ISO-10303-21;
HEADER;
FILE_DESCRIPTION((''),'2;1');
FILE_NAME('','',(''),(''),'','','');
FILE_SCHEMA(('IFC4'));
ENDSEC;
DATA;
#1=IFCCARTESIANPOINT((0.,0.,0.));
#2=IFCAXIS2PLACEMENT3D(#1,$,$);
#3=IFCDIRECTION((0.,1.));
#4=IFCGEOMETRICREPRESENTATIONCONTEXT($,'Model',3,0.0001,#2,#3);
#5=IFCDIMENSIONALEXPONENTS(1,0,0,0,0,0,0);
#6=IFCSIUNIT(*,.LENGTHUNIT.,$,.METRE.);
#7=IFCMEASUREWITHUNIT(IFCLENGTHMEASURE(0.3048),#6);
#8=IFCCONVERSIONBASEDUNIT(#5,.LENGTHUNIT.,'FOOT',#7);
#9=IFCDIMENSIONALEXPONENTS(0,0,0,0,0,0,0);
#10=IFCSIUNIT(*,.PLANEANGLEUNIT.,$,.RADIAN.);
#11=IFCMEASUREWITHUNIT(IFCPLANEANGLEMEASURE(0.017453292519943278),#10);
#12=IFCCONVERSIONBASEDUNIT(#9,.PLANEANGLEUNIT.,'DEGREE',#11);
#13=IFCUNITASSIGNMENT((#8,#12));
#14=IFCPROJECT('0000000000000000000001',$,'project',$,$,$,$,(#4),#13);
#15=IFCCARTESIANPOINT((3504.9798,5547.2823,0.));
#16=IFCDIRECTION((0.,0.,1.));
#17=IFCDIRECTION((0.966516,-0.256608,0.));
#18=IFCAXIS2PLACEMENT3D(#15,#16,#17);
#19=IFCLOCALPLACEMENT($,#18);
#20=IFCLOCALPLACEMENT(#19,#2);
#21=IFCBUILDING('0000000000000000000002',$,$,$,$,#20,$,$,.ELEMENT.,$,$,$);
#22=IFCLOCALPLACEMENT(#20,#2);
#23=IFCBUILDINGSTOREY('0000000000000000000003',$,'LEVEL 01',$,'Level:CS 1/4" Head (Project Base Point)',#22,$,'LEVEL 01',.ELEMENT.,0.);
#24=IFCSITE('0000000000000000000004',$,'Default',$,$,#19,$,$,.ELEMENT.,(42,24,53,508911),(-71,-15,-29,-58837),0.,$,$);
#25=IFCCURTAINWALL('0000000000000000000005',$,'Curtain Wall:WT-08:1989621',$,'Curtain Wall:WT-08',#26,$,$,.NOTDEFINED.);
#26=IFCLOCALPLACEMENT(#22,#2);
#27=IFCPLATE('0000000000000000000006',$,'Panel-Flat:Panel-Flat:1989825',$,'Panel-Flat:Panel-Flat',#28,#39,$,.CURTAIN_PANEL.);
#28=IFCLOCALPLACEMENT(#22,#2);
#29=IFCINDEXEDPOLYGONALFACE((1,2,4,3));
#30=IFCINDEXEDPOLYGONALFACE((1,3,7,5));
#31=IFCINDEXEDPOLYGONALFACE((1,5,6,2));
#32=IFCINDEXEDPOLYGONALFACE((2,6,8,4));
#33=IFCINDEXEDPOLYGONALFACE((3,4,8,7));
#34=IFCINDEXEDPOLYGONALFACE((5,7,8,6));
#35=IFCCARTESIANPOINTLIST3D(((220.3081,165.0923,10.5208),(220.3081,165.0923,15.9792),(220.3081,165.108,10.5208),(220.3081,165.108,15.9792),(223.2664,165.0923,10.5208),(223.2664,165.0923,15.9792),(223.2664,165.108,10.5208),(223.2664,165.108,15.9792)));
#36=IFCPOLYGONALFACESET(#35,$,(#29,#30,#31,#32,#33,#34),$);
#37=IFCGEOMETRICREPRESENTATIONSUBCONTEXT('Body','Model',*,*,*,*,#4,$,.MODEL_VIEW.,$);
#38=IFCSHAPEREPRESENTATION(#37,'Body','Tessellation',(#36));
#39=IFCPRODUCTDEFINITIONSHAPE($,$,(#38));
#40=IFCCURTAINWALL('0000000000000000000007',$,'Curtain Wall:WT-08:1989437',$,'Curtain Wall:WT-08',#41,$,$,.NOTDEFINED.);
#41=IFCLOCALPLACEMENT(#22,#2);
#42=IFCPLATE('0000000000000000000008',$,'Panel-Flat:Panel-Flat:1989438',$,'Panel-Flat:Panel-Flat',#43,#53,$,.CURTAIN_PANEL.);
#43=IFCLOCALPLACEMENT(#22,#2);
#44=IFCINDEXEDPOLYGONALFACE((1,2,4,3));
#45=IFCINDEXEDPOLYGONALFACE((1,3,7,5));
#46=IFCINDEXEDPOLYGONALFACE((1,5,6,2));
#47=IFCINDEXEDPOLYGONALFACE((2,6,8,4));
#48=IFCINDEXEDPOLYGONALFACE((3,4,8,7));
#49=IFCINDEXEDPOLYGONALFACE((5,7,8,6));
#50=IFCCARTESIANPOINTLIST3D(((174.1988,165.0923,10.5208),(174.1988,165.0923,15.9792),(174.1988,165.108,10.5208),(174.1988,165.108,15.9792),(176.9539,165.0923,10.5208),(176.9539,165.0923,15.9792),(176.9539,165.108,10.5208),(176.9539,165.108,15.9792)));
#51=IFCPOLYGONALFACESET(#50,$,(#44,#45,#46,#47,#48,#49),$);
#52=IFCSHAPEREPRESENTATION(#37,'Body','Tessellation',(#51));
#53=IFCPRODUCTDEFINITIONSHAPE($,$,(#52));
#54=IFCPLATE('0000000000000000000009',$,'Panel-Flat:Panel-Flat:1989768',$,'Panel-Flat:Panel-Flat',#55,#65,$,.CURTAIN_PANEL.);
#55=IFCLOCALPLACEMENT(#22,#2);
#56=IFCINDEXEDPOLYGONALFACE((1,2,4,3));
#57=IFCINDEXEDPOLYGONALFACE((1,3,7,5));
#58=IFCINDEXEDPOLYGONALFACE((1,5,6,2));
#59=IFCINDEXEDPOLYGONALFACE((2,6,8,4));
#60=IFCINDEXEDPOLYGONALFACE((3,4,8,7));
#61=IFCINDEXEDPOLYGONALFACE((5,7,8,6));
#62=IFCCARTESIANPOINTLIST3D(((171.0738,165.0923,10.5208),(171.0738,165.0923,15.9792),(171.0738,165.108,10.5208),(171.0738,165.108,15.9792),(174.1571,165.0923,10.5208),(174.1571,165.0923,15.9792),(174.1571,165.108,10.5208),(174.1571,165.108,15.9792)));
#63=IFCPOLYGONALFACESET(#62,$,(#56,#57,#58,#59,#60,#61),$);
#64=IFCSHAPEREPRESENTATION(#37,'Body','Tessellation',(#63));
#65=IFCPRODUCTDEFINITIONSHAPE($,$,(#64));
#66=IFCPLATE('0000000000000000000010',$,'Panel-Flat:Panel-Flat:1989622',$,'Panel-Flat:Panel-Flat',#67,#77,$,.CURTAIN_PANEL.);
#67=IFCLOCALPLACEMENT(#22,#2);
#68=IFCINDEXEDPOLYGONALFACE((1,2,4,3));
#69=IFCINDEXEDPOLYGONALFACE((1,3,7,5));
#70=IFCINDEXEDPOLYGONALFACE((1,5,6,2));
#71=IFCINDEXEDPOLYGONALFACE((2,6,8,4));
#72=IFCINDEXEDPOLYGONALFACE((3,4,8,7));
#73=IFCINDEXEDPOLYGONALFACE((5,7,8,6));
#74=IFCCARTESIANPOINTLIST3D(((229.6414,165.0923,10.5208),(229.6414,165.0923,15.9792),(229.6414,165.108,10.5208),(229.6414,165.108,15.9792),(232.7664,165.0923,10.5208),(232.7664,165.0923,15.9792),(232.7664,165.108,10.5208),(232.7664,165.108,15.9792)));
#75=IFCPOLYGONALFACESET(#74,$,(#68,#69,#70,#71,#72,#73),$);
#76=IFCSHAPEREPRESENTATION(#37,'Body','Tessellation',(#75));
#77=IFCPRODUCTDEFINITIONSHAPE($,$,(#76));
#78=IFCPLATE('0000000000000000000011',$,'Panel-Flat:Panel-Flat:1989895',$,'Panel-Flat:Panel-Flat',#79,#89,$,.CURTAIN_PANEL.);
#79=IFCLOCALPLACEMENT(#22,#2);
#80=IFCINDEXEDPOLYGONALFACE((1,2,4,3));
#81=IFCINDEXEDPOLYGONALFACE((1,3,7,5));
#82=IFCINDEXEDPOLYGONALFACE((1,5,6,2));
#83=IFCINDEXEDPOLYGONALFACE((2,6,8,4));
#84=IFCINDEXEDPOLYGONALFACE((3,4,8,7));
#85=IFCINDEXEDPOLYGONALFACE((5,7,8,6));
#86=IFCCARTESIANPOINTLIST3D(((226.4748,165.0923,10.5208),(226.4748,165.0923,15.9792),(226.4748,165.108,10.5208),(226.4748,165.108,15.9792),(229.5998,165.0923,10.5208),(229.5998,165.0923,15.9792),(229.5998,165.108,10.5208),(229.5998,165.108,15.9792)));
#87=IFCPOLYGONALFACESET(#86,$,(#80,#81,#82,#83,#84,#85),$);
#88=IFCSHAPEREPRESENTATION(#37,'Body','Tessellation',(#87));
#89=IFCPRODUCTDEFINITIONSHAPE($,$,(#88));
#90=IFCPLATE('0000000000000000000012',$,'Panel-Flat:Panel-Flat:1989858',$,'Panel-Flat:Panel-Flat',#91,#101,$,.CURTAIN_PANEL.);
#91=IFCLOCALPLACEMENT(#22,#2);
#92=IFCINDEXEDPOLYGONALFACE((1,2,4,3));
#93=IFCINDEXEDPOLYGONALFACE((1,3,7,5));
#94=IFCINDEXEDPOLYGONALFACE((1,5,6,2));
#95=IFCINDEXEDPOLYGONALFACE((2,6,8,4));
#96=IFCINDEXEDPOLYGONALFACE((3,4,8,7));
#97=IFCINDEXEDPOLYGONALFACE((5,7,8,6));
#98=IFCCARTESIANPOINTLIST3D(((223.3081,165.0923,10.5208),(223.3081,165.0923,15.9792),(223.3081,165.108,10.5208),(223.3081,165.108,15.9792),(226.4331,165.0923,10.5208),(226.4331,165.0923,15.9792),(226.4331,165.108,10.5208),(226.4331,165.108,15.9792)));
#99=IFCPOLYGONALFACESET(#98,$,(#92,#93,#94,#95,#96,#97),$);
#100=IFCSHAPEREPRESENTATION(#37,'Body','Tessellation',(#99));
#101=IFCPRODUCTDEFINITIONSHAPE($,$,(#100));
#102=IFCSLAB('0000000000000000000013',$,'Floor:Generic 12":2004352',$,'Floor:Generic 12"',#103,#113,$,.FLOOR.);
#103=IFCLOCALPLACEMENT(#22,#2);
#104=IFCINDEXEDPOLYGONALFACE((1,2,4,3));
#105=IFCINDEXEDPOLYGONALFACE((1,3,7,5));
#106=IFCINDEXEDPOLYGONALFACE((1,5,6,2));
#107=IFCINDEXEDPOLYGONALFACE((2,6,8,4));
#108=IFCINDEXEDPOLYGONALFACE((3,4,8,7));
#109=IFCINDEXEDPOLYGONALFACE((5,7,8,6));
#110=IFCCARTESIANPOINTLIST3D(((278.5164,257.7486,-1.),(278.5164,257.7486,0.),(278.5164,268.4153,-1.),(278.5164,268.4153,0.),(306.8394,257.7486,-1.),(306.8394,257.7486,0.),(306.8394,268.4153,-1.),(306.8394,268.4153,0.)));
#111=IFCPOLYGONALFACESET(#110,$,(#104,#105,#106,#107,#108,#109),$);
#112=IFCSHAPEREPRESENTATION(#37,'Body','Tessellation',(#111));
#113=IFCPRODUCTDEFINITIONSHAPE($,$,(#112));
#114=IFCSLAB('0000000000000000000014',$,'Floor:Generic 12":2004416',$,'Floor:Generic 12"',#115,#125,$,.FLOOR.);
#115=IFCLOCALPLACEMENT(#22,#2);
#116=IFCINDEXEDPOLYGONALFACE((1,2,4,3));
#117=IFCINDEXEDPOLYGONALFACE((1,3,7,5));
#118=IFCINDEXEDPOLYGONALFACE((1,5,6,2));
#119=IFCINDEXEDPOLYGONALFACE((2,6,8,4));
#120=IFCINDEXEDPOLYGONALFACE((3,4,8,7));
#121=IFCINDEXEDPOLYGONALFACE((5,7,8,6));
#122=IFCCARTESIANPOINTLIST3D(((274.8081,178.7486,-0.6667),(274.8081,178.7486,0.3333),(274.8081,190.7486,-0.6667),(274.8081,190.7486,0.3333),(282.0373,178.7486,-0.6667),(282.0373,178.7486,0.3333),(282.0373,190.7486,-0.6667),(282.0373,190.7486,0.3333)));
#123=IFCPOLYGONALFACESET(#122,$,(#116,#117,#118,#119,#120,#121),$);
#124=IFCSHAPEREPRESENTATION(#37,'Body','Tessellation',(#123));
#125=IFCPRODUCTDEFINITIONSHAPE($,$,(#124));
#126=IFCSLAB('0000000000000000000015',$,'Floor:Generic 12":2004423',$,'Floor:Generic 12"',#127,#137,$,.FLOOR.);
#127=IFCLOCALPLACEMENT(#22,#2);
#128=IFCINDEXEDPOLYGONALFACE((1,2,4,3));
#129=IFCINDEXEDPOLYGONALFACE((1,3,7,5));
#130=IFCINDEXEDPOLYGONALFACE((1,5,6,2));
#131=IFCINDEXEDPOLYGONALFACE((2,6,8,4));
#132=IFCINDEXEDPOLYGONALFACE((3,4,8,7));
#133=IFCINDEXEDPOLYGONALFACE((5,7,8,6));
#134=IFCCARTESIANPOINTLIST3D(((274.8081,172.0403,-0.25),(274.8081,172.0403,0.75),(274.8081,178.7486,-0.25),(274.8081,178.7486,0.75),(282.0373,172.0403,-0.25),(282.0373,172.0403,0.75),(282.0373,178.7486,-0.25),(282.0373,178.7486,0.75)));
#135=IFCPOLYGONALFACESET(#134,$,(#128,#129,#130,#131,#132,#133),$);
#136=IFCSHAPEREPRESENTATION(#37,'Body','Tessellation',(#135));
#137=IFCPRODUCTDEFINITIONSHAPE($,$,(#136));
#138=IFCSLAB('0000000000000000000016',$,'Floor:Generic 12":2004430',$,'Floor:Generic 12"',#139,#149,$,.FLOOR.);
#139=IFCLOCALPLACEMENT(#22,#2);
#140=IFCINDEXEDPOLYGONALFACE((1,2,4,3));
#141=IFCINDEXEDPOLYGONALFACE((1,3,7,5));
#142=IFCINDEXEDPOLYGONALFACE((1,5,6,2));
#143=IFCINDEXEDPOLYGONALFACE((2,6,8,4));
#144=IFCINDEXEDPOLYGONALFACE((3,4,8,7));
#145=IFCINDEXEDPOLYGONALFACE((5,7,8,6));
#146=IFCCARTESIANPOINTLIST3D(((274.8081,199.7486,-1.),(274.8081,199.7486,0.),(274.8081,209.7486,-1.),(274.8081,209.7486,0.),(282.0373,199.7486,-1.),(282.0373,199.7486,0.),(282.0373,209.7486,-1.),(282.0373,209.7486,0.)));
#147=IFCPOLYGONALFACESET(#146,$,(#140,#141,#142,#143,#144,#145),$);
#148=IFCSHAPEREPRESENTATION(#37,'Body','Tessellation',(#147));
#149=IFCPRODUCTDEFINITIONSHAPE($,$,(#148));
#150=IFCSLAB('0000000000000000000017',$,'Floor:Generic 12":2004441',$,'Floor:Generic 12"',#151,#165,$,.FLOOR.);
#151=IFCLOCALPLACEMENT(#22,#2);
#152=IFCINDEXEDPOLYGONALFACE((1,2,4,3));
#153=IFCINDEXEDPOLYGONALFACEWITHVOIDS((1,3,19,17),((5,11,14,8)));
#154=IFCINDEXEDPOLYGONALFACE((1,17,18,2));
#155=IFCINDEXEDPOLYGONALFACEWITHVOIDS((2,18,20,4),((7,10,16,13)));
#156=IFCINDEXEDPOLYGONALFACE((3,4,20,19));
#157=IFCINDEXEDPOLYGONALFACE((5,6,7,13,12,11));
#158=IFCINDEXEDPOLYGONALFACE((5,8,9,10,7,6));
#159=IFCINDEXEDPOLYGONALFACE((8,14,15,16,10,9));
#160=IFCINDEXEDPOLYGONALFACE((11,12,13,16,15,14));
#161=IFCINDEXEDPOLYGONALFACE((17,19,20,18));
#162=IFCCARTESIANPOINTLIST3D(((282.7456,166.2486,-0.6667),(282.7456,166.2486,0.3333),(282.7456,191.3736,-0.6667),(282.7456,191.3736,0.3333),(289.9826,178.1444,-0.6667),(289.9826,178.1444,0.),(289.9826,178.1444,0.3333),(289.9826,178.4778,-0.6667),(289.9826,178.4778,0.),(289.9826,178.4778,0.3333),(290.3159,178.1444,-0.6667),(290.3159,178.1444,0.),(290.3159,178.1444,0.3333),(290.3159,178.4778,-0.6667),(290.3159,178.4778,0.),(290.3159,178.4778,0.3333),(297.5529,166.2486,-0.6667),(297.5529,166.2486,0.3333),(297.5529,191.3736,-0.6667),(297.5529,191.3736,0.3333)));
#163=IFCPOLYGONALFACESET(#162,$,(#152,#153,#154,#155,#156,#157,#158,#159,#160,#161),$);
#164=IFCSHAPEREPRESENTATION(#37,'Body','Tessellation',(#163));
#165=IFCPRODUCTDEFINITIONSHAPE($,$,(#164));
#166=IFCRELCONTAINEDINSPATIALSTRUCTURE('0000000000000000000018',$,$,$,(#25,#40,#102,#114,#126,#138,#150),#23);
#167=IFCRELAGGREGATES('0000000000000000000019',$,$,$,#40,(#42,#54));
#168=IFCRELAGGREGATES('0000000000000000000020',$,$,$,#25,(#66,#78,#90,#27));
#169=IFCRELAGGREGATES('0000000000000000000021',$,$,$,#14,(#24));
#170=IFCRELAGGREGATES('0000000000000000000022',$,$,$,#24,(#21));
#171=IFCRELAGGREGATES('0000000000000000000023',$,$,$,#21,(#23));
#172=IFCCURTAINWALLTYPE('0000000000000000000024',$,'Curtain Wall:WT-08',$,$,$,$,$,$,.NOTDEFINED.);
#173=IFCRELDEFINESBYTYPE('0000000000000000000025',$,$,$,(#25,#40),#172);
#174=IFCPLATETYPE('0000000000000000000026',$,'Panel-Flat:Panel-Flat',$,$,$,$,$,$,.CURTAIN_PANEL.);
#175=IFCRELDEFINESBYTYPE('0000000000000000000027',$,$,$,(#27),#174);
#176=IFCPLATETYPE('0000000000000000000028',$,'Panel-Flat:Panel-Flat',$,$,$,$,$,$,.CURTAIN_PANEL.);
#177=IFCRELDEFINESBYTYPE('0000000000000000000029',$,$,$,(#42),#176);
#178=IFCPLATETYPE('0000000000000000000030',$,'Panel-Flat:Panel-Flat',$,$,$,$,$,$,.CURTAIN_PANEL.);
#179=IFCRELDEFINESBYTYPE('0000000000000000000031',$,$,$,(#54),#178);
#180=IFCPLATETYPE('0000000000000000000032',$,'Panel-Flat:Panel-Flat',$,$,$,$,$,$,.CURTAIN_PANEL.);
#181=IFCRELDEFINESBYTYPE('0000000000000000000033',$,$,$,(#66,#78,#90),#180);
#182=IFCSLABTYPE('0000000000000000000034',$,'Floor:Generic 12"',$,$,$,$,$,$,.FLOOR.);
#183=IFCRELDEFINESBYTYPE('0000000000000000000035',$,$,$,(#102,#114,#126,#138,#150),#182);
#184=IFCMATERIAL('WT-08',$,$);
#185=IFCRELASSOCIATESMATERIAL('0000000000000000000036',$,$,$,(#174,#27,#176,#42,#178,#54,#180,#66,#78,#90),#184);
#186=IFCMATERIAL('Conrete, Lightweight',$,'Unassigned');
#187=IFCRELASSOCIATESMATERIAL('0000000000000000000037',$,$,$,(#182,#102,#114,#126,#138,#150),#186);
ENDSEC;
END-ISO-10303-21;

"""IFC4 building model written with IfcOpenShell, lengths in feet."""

from ifc_helpers import new_model, entity, si_unit, converted_unit, direction, frame, origin, place, context, subcontext, project, spatial, indexed_curve, outline, extrude, source, transform, mapped, material, type_object, type_shapes, element, aggregate, save


model = new_model("IFC4")

# Units and contexts
model_context = context("Model", 3, precision=0.0001, world=origin(), true_north=direction((0.0, 1.0)))
body_context = subcontext(model_context, "Body", "Model", "MODEL_VIEW")
ifc_project = project(units=[converted_unit("LENGTHUNIT", "FOOT", entity("IfcLengthMeasure", 0.3048), si_unit("LENGTHUNIT", "METRE"), dimensions=[1, 0, 0, 0, 0, 0, 0]), converted_unit("PLANEANGLEUNIT", "DEGREE", entity("IfcPlaneAngleMeasure", 0.017453292519943278), si_unit("PLANEANGLEUNIT", "RADIAN"), dimensions=[0, 0, 0, 0, 0, 0, 0])], contexts=[model_context])

# Site, building, storey
site_placement = place(None, frame((3504.9798, 5547.2823, 0.0), z_axis=(0.0, 0.0, 1.0), x_axis=(0.966516, -0.256608, 0.0)))
site = spatial("IfcSite", under=ifc_project, at=site_placement, Name="Default", CompositionType="ELEMENT", RefLatitude=(42, 24, 53, 508911), RefLongitude=(-71, -15, -29, -58837), RefElevation=0.0)
building_placement = place(site_placement, origin())
building = spatial("IfcBuilding", under=site, at=building_placement, CompositionType="ELEMENT")
storey_placement = place(building_placement, origin())
storey = spatial("IfcBuildingStorey", under=building, at=storey_placement, Name="LEVEL 01", ObjectType="Level:CS 1/4\" Head (Project Base Point)", LongName="LEVEL 01", CompositionType="ELEMENT", Elevation=0.0)

# Curtain wall, plate
curtain_wall_type_1 = type_object("IfcCurtainWallType", Name="Curtain Wall:WT-08", PredefinedType="NOTDEFINED")
curtain_wall_1_placement = place(storey_placement, origin())
curtain_wall_1 = element("IfcCurtainWall", 1, at=curtain_wall_1_placement, inside=storey, type_object=curtain_wall_type_1, Name="Curtain Wall:WT-08:1989621", ObjectType="Curtain Wall:WT-08", PredefinedType="NOTDEFINED")
ifc_material_1 = material(Name="WT-08")
plate_type_1 = type_object("IfcPlateType", Name="Panel-Flat:Panel-Flat", PredefinedType="CURTAIN_PANEL", material=ifc_material_1)
shared_shape_1 = source(origin(), body_context, "Body", "SweptSolid", [
    extrude(outline(indexed_curve([(-0.0078, -1.4792), (0.0078, -1.4792), (0.0078, 1.4792), (-0.0078, 1.4792), (-0.0078, -1.4792)], self_intersect=False)), frame((0.0, -0.0078, 0.0208), z_axis=(0.0, 0.0, 1.0), x_axis=(0.0, -1.0, 0.0)), (0.0, 0.0, 1.0), 5.4583),
])
type_shapes(plate_type_1, [shared_shape_1])
plate_1_placement = place(curtain_wall_1_placement, frame((221.7873, 165.0923, 10.5), z_axis=(0.0, 0.0, 1.0), x_axis=(-1.0, 0.0, 0.0)))
plate_1 = element("IfcPlate", 2, at=plate_1_placement, type_object=plate_type_1, material=ifc_material_1, Name="Panel-Flat:Panel-Flat:1989825", ObjectType="Panel-Flat:Panel-Flat", PredefinedType="CURTAIN_PANEL", context=body_context, shape_type="MappedRepresentation", body=[
    mapped(shared_shape_1, transform((0.0, 0.0, 0.0), scale=1.0)),
])

# Curtain wall, plates
curtain_wall_2_placement = place(storey_placement, origin())
curtain_wall_2 = element("IfcCurtainWall", 3, at=curtain_wall_2_placement, inside=storey, type_object=curtain_wall_type_1, Name="Curtain Wall:WT-08:1989437", ObjectType="Curtain Wall:WT-08", PredefinedType="NOTDEFINED")
plate_type_2 = type_object("IfcPlateType", Name="Panel-Flat:Panel-Flat", PredefinedType="CURTAIN_PANEL", material=ifc_material_1)
shared_shape_2 = source(origin(), body_context, "Body", "SweptSolid", [
    extrude(outline(indexed_curve([(-0.0078, -1.3776), (0.0078, -1.3776), (0.0078, 1.3776), (-0.0078, 1.3776), (-0.0078, -1.3776)], self_intersect=False)), frame((0.0, -0.0078, 0.0208), z_axis=(0.0, 0.0, 1.0), x_axis=(0.0, -1.0, 0.0)), (0.0, 0.0, 1.0), 5.4583),
])
type_shapes(plate_type_2, [shared_shape_2])
plate_2_placement = place(curtain_wall_2_placement, frame((175.5764, 165.0923, 10.5), z_axis=(0.0, 0.0, 1.0), x_axis=(-1.0, 0.0, 0.0)))
plate_2 = element("IfcPlate", 4, at=plate_2_placement, type_object=plate_type_2, material=ifc_material_1, Name="Panel-Flat:Panel-Flat:1989438", ObjectType="Panel-Flat:Panel-Flat", PredefinedType="CURTAIN_PANEL", context=body_context, shape_type="MappedRepresentation", body=[
    mapped(shared_shape_2, transform((0.0, 0.0, 0.0), scale=1.0)),
])
plate_type_3 = type_object("IfcPlateType", Name="Panel-Flat:Panel-Flat", PredefinedType="CURTAIN_PANEL", material=ifc_material_1)
shared_shape_3 = source(origin(), body_context, "Body", "SweptSolid", [
    extrude(outline(indexed_curve([(-0.0078, -1.5417), (0.0078, -1.5417), (0.0078, 1.5417), (-0.0078, 1.5417), (-0.0078, -1.5417)], self_intersect=False)), frame((0.0, -0.0078, 0.0208), z_axis=(0.0, 0.0, 1.0), x_axis=(0.0, -1.0, 0.0)), (0.0, 0.0, 1.0), 5.4583),
])
type_shapes(plate_type_3, [shared_shape_3])
plate_3_placement = place(curtain_wall_2_placement, frame((172.6155, 165.0923, 10.5), z_axis=(0.0, 0.0, 1.0), x_axis=(-1.0, 0.0, 0.0)))
plate_3 = element("IfcPlate", 5, at=plate_3_placement, type_object=plate_type_3, material=ifc_material_1, Name="Panel-Flat:Panel-Flat:1989768", ObjectType="Panel-Flat:Panel-Flat", PredefinedType="CURTAIN_PANEL", context=body_context, shape_type="MappedRepresentation", body=[
    mapped(shared_shape_3, transform((0.0, 0.0, 0.0), scale=1.0)),
])
aggregate(curtain_wall_2, [plate_2, plate_3])

# Plates
plate_type_4 = type_object("IfcPlateType", Name="Panel-Flat:Panel-Flat", PredefinedType="CURTAIN_PANEL", material=ifc_material_1)
shared_shape_4 = source(origin(), body_context, "Body", "SweptSolid", [
    extrude(outline(indexed_curve([(-0.0078, -1.5625), (0.0078, -1.5625), (0.0078, 1.5625), (-0.0078, 1.5625), (-0.0078, -1.5625)], self_intersect=False)), frame((0.0, -0.0078, 0.0208), z_axis=(0.0, 0.0, 1.0), x_axis=(0.0, -1.0, 0.0)), (0.0, 0.0, 1.0), 5.4583),
])
type_shapes(plate_type_4, [shared_shape_4])
plate_4_placement = place(curtain_wall_1_placement, frame((231.2039, 165.0923, 10.5), z_axis=(0.0, 0.0, 1.0), x_axis=(-1.0, 0.0, 0.0)))
plate_4 = element("IfcPlate", 6, at=plate_4_placement, type_object=plate_type_4, material=ifc_material_1, Name="Panel-Flat:Panel-Flat:1989622", ObjectType="Panel-Flat:Panel-Flat", PredefinedType="CURTAIN_PANEL", context=body_context, shape_type="MappedRepresentation", body=[
    mapped(shared_shape_4, transform((0.0, 0.0, 0.0), scale=1.0)),
])
plate_5_placement = place(curtain_wall_1_placement, frame((228.0373, 165.0923, 10.5), z_axis=(0.0, 0.0, 1.0), x_axis=(-1.0, 0.0, 0.0)))
plate_5 = element("IfcPlate", 7, at=plate_5_placement, type_object=plate_type_4, material=ifc_material_1, Name="Panel-Flat:Panel-Flat:1989895", ObjectType="Panel-Flat:Panel-Flat", PredefinedType="CURTAIN_PANEL", context=body_context, shape_type="MappedRepresentation", body=[
    mapped(shared_shape_4, transform((0.0, 0.0, 0.0), scale=1.0)),
])
plate_6_placement = place(curtain_wall_1_placement, frame((224.8706, 165.0923, 10.5), z_axis=(0.0, 0.0, 1.0), x_axis=(-1.0, 0.0, 0.0)))
plate_6 = element("IfcPlate", 8, at=plate_6_placement, type_object=plate_type_4, material=ifc_material_1, Name="Panel-Flat:Panel-Flat:1989858", ObjectType="Panel-Flat:Panel-Flat", PredefinedType="CURTAIN_PANEL", context=body_context, shape_type="MappedRepresentation", body=[
    mapped(shared_shape_4, transform((0.0, 0.0, 0.0), scale=1.0)),
])
aggregate(curtain_wall_1, [plate_4, plate_5, plate_6, plate_1])

# Shared definitions
ifc_material_2 = material(Name="Conrete, Lightweight", Category="Unassigned")
slab_type = type_object("IfcSlabType", Name="Floor:Generic 12\"", PredefinedType="FLOOR", material=ifc_material_2)

# Slabs
slab_1_placement = place(storey_placement, origin())
element("IfcSlab", 9, at=slab_1_placement, inside=storey, type_object=slab_type, material=ifc_material_2, Name="Floor:Generic 12\":2004352", ObjectType="Floor:Generic 12\"", PredefinedType="FLOOR", context=body_context, shape_type="SweptSolid", body=[
    extrude(outline(indexed_curve([(-5.3333, -14.1615), (5.3333, -14.1615), (5.3333, 14.1615), (-5.3333, 14.1615), (-5.3333, -14.1615)], self_intersect=False)), frame((292.6779, 263.0819, 0.0), z_axis=(0.0, 0.0, -1.0), x_axis=(0.0, 1.0, 0.0)), (0.0, 0.0, 1.0), 1.0),
])
slab_2_placement = place(storey_placement, origin())
element("IfcSlab", 10, at=slab_2_placement, inside=storey, type_object=slab_type, material=ifc_material_2, Name="Floor:Generic 12\":2004416", ObjectType="Floor:Generic 12\"", PredefinedType="FLOOR", context=body_context, shape_type="SweptSolid", body=[
    extrude(outline(indexed_curve([(-6.0, -3.6146), (6.0, -3.6146), (6.0, 3.6146), (-6.0, 3.6146), (-6.0, -3.6146)], self_intersect=False)), frame((278.4227, 184.7486, 0.3333), z_axis=(0.0, 0.0, -1.0), x_axis=(0.0, 1.0, 0.0)), (0.0, 0.0, 1.0), 1.0),
])
slab_3_placement = place(storey_placement, origin())
element("IfcSlab", 11, at=slab_3_placement, inside=storey, type_object=slab_type, material=ifc_material_2, Name="Floor:Generic 12\":2004423", ObjectType="Floor:Generic 12\"", PredefinedType="FLOOR", context=body_context, shape_type="SweptSolid", body=[
    extrude(outline(indexed_curve([(-3.3542, -3.6146), (3.3542, -3.6146), (3.3542, 3.6146), (-3.3542, 3.6146), (-3.3542, -3.6146)], self_intersect=False)), frame((278.4227, 175.3944, 0.75), z_axis=(0.0, 0.0, -1.0), x_axis=(0.0, 1.0, 0.0)), (0.0, 0.0, 1.0), 1.0),
])
slab_4_placement = place(storey_placement, origin())
element("IfcSlab", 12, at=slab_4_placement, inside=storey, type_object=slab_type, material=ifc_material_2, Name="Floor:Generic 12\":2004430", ObjectType="Floor:Generic 12\"", PredefinedType="FLOOR", context=body_context, shape_type="SweptSolid", body=[
    extrude(outline(indexed_curve([(-5.0, -3.6146), (5.0, -3.6146), (5.0, 3.6146), (-5.0, 3.6146), (-5.0, -3.6146)], self_intersect=False)), frame((278.4227, 204.7486, 0.0), z_axis=(0.0, 0.0, -1.0), x_axis=(0.0, 1.0, 0.0)), (0.0, 0.0, 1.0), 1.0),
])

# Slab, opening
slab_5_placement = place(storey_placement, origin())
slab_5 = element("IfcSlab", 13, at=slab_5_placement, inside=storey, type_object=slab_type, material=ifc_material_2, Name="Floor:Generic 12\":2004441", ObjectType="Floor:Generic 12\"", PredefinedType="FLOOR", context=body_context, shape_type="SweptSolid", body=[
    extrude(outline(indexed_curve([(-12.5625, -7.4036), (12.5625, -7.4036), (12.5625, 7.4036), (-12.5625, 7.4036), (-12.5625, -7.4036)], self_intersect=False), holes=[indexed_curve([(0.6667, 0.1667), (0.6667, -0.1667), (0.3333, -0.1667), (0.3333, 0.1667), (0.6667, 0.1667)], self_intersect=False)]), frame((290.1493, 178.8111, -0.6667), z_axis=(0.0, 0.0, 1.0), x_axis=(0.0, -1.0, 0.0)), (0.0, 0.0, 1.0), 1.0),
])
opening_1_placement = place(slab_5_placement, origin())
element("IfcOpeningElement", 14, at=opening_1_placement, cuts=slab_5, PredefinedType="OPENING", context=body_context, shape_type="SweptSolid", body=[
    extrude(outline(indexed_curve([(290.3159, 178.1444), (290.3159, 178.4778), (289.9826, 178.4778), (289.9826, 178.1444), (290.3159, 178.1444)], self_intersect=False)), origin(), (0.0, 0.0, -1.0), 14.8073),
])

save(model, "model.ifc")
